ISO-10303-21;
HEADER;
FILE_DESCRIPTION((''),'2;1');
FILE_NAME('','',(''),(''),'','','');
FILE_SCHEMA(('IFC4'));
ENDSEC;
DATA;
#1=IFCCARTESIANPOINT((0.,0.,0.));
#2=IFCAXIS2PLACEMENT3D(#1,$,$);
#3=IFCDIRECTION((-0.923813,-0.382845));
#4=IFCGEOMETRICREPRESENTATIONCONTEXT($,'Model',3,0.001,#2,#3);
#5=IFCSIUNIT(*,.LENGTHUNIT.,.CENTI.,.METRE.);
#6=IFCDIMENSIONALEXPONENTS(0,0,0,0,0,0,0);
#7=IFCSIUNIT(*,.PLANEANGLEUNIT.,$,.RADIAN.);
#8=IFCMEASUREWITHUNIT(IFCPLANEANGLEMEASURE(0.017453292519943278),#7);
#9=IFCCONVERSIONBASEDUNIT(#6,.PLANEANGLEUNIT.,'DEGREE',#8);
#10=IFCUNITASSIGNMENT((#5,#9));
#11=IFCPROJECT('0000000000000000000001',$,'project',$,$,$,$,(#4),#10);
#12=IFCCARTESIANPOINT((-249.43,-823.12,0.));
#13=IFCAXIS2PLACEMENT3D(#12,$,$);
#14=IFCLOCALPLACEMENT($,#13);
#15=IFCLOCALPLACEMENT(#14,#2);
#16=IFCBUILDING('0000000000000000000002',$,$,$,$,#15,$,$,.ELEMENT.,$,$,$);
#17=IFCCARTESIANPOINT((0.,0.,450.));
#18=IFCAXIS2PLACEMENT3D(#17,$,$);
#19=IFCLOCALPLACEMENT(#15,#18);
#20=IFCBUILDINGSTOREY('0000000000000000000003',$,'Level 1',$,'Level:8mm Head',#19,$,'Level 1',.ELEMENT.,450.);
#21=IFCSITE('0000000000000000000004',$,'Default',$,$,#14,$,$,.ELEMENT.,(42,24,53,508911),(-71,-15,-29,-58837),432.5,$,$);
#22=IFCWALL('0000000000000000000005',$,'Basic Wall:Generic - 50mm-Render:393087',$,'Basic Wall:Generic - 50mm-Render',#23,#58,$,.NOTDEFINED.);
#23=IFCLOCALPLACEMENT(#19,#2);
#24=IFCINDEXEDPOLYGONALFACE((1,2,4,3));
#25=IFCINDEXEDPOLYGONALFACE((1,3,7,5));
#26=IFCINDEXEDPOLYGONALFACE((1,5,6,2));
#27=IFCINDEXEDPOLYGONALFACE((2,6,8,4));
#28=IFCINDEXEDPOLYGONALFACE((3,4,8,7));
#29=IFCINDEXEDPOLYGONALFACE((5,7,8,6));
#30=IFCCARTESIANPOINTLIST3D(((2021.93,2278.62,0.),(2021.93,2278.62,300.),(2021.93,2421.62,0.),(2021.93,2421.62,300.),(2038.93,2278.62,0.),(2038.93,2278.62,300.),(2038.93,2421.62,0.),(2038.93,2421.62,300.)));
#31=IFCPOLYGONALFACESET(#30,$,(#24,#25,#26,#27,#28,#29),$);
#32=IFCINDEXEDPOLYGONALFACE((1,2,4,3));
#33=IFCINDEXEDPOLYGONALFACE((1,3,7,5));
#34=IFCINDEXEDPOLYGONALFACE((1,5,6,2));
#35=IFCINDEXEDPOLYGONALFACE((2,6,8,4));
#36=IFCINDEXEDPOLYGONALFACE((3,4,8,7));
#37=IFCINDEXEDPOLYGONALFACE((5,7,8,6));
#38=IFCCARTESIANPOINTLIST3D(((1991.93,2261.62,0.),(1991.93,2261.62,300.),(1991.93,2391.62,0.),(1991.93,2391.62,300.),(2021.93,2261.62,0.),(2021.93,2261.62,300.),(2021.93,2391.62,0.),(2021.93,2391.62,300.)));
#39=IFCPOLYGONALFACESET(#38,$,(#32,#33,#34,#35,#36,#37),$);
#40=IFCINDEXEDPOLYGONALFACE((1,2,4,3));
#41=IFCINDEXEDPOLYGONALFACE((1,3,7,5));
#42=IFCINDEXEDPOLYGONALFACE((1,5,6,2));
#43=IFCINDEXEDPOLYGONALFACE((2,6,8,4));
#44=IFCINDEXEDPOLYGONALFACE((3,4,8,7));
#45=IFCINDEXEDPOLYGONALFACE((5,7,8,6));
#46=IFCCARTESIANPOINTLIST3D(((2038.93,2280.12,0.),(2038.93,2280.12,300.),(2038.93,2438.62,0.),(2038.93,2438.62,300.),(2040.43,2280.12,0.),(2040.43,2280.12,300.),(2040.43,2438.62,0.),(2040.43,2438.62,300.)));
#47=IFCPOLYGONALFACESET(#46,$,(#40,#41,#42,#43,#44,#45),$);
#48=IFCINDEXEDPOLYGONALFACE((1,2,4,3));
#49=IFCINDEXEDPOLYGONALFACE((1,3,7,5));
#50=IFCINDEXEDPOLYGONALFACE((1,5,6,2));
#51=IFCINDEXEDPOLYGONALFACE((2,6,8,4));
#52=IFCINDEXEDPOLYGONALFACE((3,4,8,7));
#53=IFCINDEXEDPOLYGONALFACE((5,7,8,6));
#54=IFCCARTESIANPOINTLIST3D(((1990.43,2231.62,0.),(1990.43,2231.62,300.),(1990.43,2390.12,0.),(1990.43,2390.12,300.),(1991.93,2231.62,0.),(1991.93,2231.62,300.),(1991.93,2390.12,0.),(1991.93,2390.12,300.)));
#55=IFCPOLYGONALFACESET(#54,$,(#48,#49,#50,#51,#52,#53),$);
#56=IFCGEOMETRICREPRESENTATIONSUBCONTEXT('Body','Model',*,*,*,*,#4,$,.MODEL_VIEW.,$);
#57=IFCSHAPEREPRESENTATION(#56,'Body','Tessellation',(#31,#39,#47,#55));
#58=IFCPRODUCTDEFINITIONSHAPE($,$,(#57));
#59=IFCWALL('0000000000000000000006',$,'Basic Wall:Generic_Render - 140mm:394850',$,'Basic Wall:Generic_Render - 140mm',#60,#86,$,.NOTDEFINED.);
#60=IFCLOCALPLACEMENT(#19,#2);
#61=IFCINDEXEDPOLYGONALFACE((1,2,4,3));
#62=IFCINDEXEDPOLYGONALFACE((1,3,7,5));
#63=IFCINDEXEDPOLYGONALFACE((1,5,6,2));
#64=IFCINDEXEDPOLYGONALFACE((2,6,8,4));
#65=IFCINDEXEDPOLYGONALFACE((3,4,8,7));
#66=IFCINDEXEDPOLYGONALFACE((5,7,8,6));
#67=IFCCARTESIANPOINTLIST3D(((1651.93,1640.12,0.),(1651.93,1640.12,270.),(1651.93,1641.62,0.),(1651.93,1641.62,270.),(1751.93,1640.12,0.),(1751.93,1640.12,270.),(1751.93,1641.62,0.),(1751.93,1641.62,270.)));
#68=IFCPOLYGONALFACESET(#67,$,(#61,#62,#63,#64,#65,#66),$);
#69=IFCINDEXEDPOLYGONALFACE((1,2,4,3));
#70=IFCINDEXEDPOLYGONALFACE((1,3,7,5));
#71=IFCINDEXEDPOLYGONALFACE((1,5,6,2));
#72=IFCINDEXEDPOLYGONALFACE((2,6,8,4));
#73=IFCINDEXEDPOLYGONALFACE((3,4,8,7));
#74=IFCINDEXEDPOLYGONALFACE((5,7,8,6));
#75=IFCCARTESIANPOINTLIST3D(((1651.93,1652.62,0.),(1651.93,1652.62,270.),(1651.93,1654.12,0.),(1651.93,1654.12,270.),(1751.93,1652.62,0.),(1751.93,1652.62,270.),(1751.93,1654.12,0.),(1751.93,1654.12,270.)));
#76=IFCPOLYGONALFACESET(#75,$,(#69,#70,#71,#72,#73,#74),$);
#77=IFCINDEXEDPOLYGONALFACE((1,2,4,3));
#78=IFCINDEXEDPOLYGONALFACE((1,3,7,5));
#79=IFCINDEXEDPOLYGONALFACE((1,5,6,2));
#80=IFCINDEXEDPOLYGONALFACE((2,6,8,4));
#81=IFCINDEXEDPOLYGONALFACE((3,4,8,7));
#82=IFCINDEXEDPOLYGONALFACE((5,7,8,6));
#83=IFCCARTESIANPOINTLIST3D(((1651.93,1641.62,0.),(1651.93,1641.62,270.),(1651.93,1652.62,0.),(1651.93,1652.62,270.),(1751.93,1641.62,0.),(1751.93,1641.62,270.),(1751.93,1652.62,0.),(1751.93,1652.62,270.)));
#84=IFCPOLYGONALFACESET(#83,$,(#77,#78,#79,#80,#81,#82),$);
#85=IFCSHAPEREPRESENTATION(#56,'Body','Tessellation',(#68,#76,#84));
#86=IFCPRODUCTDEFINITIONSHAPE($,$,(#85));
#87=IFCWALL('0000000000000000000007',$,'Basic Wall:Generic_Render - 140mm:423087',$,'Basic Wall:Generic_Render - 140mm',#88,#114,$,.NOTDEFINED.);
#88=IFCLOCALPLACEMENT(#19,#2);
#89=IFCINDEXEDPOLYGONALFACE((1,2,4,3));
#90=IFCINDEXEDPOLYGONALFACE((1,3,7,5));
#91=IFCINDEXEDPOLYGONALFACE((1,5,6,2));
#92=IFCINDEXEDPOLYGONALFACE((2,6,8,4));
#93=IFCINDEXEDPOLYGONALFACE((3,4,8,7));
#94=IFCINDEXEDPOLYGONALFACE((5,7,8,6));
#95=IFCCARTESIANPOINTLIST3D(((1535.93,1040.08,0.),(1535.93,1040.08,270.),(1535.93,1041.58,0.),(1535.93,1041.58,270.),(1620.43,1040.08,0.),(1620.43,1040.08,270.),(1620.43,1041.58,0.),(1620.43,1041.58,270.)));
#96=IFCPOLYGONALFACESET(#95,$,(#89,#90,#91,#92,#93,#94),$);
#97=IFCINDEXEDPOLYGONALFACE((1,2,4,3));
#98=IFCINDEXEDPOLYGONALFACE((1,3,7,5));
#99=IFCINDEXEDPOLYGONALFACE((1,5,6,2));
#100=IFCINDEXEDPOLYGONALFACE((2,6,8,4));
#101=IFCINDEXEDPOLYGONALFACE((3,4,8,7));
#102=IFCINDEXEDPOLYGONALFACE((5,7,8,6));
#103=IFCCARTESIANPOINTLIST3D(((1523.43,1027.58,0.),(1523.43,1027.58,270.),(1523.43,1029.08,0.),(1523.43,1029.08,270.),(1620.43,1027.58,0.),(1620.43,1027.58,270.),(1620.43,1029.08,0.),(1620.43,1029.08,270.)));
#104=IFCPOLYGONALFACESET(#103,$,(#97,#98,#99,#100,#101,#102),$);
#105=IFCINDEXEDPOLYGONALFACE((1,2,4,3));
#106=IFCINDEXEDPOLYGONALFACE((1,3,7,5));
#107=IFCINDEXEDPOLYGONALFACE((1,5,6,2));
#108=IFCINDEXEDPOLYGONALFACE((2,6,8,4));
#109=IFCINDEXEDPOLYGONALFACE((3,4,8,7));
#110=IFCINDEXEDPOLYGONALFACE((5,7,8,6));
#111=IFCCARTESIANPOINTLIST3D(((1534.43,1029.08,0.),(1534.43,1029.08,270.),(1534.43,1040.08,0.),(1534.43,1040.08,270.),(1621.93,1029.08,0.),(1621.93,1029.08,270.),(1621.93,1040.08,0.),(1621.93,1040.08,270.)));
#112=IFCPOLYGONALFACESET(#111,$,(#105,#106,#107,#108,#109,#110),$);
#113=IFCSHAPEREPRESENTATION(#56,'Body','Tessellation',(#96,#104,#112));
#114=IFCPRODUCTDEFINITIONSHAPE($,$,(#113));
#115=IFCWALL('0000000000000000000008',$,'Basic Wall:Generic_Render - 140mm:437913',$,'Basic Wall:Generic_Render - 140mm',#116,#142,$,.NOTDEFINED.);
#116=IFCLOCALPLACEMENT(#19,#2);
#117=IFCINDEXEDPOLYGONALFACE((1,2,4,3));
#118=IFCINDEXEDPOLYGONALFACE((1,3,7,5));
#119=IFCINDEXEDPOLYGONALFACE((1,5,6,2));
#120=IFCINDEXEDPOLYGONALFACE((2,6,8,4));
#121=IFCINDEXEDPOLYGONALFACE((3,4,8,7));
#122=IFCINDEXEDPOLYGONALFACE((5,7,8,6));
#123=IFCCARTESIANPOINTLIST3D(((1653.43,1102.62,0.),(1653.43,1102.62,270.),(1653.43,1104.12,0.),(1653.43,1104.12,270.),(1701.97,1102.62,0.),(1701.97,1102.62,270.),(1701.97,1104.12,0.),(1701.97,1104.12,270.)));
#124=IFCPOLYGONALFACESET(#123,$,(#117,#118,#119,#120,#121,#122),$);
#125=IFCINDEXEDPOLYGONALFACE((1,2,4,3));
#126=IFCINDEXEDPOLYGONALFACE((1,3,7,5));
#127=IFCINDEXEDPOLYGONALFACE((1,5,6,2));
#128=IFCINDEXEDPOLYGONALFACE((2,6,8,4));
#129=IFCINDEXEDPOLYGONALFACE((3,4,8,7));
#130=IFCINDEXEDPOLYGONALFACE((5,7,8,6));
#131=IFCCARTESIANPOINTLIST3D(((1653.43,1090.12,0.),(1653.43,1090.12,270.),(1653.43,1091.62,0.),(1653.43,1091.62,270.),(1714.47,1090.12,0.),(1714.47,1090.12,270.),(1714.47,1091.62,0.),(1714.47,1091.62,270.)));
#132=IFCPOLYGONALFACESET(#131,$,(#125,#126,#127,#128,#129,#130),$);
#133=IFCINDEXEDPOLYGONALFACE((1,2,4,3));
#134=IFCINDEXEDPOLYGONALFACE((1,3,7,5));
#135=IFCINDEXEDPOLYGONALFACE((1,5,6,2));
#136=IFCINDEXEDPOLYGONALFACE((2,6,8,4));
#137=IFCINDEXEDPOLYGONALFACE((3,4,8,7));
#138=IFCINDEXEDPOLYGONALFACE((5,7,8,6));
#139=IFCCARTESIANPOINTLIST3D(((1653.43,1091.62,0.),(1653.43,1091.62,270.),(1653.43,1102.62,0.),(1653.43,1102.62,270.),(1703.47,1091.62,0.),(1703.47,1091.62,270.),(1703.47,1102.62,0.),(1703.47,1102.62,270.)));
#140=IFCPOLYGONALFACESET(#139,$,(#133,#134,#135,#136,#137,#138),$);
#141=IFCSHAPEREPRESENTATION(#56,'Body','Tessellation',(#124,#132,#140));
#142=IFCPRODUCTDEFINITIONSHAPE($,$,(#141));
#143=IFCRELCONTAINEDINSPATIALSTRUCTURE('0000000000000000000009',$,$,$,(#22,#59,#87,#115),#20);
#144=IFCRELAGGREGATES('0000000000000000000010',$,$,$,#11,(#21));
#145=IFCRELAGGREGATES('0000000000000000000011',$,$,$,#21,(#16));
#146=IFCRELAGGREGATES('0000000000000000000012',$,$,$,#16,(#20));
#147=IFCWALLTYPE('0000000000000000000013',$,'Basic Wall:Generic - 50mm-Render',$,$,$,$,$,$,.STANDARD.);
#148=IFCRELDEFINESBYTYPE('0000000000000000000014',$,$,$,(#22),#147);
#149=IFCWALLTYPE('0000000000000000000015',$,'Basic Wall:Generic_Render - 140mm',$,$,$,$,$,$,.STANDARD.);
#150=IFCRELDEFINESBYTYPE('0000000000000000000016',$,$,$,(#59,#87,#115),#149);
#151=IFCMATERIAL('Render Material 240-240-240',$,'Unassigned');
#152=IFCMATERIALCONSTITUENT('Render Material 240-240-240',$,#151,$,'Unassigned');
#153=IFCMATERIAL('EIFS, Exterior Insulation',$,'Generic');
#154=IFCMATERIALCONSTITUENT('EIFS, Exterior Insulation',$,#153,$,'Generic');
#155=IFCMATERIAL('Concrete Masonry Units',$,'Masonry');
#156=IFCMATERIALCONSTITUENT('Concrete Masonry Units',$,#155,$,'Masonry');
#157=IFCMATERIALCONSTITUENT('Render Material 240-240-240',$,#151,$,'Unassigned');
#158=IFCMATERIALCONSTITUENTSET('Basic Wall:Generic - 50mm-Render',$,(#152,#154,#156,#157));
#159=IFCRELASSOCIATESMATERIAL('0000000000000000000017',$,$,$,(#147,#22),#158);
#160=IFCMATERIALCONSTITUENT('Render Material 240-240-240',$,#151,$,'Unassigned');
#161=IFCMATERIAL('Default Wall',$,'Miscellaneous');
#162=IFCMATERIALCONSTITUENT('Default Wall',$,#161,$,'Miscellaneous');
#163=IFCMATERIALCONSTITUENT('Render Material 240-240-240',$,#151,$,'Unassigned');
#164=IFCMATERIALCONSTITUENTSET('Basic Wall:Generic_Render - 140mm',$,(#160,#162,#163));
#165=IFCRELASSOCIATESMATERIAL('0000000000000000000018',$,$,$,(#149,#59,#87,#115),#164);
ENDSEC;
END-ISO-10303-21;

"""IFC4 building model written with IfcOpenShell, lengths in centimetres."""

from ifc_helpers import new_model, entity, si_unit, converted_unit, direction, frame, origin, place, context, subcontext, project, spatial, indexed_curve, outline, extrude, material, constituent, constituent_set, type_object, element, save


model = new_model("IFC4")

# Units and contexts
model_context = context("Model", 3, precision=0.001, world=origin(), true_north=direction((-0.923813, -0.382845)))
body_context = subcontext(model_context, "Body", "Model", "MODEL_VIEW")
ifc_project = project(units=[si_unit("LENGTHUNIT", "METRE", prefix="CENTI"), converted_unit("PLANEANGLEUNIT", "DEGREE", entity("IfcPlaneAngleMeasure", 0.017453292519943278), si_unit("PLANEANGLEUNIT", "RADIAN"), dimensions=[0, 0, 0, 0, 0, 0, 0])], contexts=[model_context])

# Site, building, storey
site_placement = place(None, frame((-249.43, -823.12, 0.0)))
site = spatial("IfcSite", under=ifc_project, at=site_placement, Name="Default", CompositionType="ELEMENT", RefLatitude=(42, 24, 53, 508911), RefLongitude=(-71, -15, -29, -58837), RefElevation=432.5)
building_placement = place(site_placement, origin())
building = spatial("IfcBuilding", under=site, at=building_placement, CompositionType="ELEMENT")
storey_placement = place(building_placement, frame((0.0, 0.0, 450.0)))
storey = spatial("IfcBuildingStorey", under=building, at=storey_placement, Name="Level 1", ObjectType="Level:8mm Head", LongName="Level 1", CompositionType="ELEMENT", Elevation=450.0)

# Wall
ifc_material_1 = material(Name="Concrete Masonry Units", Category="Masonry")
ifc_material_2 = material(Name="Render Material 240-240-240", Category="Unassigned")
ifc_material_3 = material(Name="Default Wall", Category="Miscellaneous")
ifc_constituent_1 = constituent(ifc_material_2, Name="Render Material 240-240-240", Category="Unassigned")
ifc_material_4 = material(Name="EIFS, Exterior Insulation", Category="Generic")
ifc_constituent_2 = constituent(ifc_material_4, Name="EIFS, Exterior Insulation", Category="Generic")
ifc_constituent_3 = constituent(ifc_material_1, Name="Concrete Masonry Units", Category="Masonry")
ifc_constituent_4 = constituent(ifc_material_2, Name="Render Material 240-240-240", Category="Unassigned")
ifc_constituent_set_1 = constituent_set(constituents=[ifc_constituent_1, ifc_constituent_2, ifc_constituent_3, ifc_constituent_4], Name="Basic Wall:Generic - 50mm-Render")
wall_type_1 = type_object("IfcWallType", Name="Basic Wall:Generic - 50mm-Render", PredefinedType="STANDARD", material=ifc_constituent_set_1)
wall_1_placement = place(storey_placement, frame((2015.43, 2280.12, 0.0), z_axis=(0.0, 0.0, 1.0), x_axis=(0.0, 1.0, 0.0)))
element("IfcWall", 1, at=wall_1_placement, inside=storey, type_object=wall_type_1, material=ifc_constituent_set_1, Name="Basic Wall:Generic - 50mm-Render:393087", ObjectType="Basic Wall:Generic - 50mm-Render", PredefinedType="NOTDEFINED", context=body_context, shape_type="SweptSolid", body=[
    extrude(outline(indexed_curve([(-8.5, -71.5), (8.5, -71.5), (8.5, 71.5), (-8.5, 71.5), (-8.5, -71.5)], self_intersect=False)), frame((70.0, -15.0, 0.0), z_axis=(0.0, 0.0, 1.0), x_axis=(0.0, 1.0, 0.0)), (0.0, 0.0, 1.0), 300.0),
    extrude(outline(indexed_curve([(-15.0, -65.0), (15.0, -65.0), (15.0, 65.0), (-15.0, 65.0), (-15.0, -65.0)], self_intersect=False)), frame((46.5, 8.5, 0.0), z_axis=(0.0, 0.0, 1.0), x_axis=(0.0, -1.0, 0.0)), (0.0, 0.0, 1.0), 300.0),
    extrude(outline(indexed_curve([(-0.75, -79.25), (0.75, -79.25), (0.75, 79.25), (-0.75, 79.25), (-0.75, -79.25)], self_intersect=False)), frame((79.25, -24.25, 0.0), z_axis=(0.0, 0.0, 1.0), x_axis=(0.0, 1.0, 0.0)), (0.0, 0.0, 1.0), 300.0),
    extrude(outline(indexed_curve([(-0.75, -79.25), (0.75, -79.25), (0.75, 79.25), (-0.75, 79.25), (-0.75, -79.25)], self_intersect=False)), frame((30.75, 24.25, 0.0), z_axis=(0.0, 0.0, 1.0), x_axis=(0.0, 1.0, 0.0)), (0.0, 0.0, 1.0), 300.0),
])

# Walls
ifc_constituent_5 = constituent(ifc_material_2, Name="Render Material 240-240-240", Category="Unassigned")
ifc_constituent_6 = constituent(ifc_material_3, Name="Default Wall", Category="Miscellaneous")
ifc_constituent_7 = constituent(ifc_material_2, Name="Render Material 240-240-240", Category="Unassigned")
ifc_constituent_set_2 = constituent_set(constituents=[ifc_constituent_5, ifc_constituent_6, ifc_constituent_7], Name="Basic Wall:Generic_Render - 140mm")
wall_type_2 = type_object("IfcWallType", Name="Basic Wall:Generic_Render - 140mm", PredefinedType="STANDARD", material=ifc_constituent_set_2)
wall_2_placement = place(storey_placement, frame((1651.93, 1647.12, 0.0)))
element("IfcWall", 2, at=wall_2_placement, inside=storey, type_object=wall_type_2, material=ifc_constituent_set_2, Name="Basic Wall:Generic_Render - 140mm:394850", ObjectType="Basic Wall:Generic_Render - 140mm", PredefinedType="NOTDEFINED", context=body_context, shape_type="SweptSolid", body=[
    extrude(outline(indexed_curve([(-0.75, -50.0), (0.75, -50.0), (0.75, 50.0), (-0.75, 50.0), (-0.75, -50.0)], self_intersect=False)), frame((50.0, -6.25, 0.0), z_axis=(0.0, 0.0, 1.0), x_axis=(0.0, 1.0, 0.0)), (0.0, 0.0, 1.0), 270.0),
    extrude(outline(indexed_curve([(-0.75, -50.0), (0.75, -50.0), (0.75, 50.0), (-0.75, 50.0), (-0.75, -50.0)], self_intersect=False)), frame((50.0, 6.25, 0.0), z_axis=(0.0, 0.0, 1.0), x_axis=(0.0, -1.0, 0.0)), (0.0, 0.0, 1.0), 270.0),
    extrude(outline(indexed_curve([(-50.0, -5.5), (50.0, -5.5), (50.0, 5.5), (-50.0, 5.5), (-50.0, -5.5)], self_intersect=False)), frame((50.0, 0.0, 0.0)), (0.0, 0.0, 1.0), 270.0),
])
wall_3_placement = place(storey_placement, frame((1535.93, 1034.58, 0.0)))
element("IfcWall", 3, at=wall_3_placement, inside=storey, type_object=wall_type_2, material=ifc_constituent_set_2, Name="Basic Wall:Generic_Render - 140mm:423087", ObjectType="Basic Wall:Generic_Render - 140mm", PredefinedType="NOTDEFINED", context=body_context, shape_type="SweptSolid", body=[
    extrude(outline(indexed_curve([(-0.75, -42.25), (0.75, -42.25), (0.75, 42.25), (-0.75, 42.25), (-0.75, -42.25)], self_intersect=False)), frame((42.25, 6.25, 0.0), z_axis=(0.0, 0.0, 1.0), x_axis=(0.0, -1.0, 0.0)), (0.0, 0.0, 1.0), 270.0),
    extrude(outline(indexed_curve([(-0.75, -48.5), (0.75, -48.5), (0.75, 48.5), (-0.75, 48.5), (-0.75, -48.5)], self_intersect=False)), frame((36.0, -6.25, 0.0), z_axis=(0.0, 0.0, 1.0), x_axis=(0.0, 1.0, 0.0)), (0.0, 0.0, 1.0), 270.0),
    extrude(outline(indexed_curve([(-43.75, -5.5), (43.75, -5.5), (43.75, 5.5), (-43.75, 5.5), (-43.75, -5.5)], self_intersect=False)), frame((42.25, 0.0, 0.0)), (0.0, 0.0, 1.0), 270.0),
])
wall_4_placement = place(storey_placement, frame((1701.97, 1097.12, 0.0), z_axis=(0.0, 0.0, 1.0), x_axis=(-1.0, 0.0, 0.0)))
element("IfcWall", 4, at=wall_4_placement, inside=storey, type_object=wall_type_2, material=ifc_constituent_set_2, Name="Basic Wall:Generic_Render - 140mm:437913", ObjectType="Basic Wall:Generic_Render - 140mm", PredefinedType="NOTDEFINED", context=body_context, shape_type="SweptSolid", body=[
    extrude(outline(indexed_curve([(-0.75, -24.27), (0.75, -24.27), (0.75, 24.27), (-0.75, 24.27), (-0.75, -24.27)], self_intersect=False)), frame((24.27, -6.25, 0.0), z_axis=(0.0, 0.0, 1.0), x_axis=(0.0, 1.0, 0.0)), (0.0, 0.0, 1.0), 270.0),
    extrude(outline(indexed_curve([(-0.75, -30.52), (0.75, -30.52), (0.75, 30.52), (-0.75, 30.52), (-0.75, -30.52)], self_intersect=False)), frame((18.02, 6.25, 0.0), z_axis=(0.0, 0.0, 1.0), x_axis=(0.0, -1.0, 0.0)), (0.0, 0.0, 1.0), 270.0),
    extrude(outline(indexed_curve([(-25.02, -5.5), (25.02, -5.5), (25.02, 5.5), (-25.02, 5.5), (-25.02, -5.5)], self_intersect=False)), frame((23.52, 0.0, 0.0)), (0.0, 0.0, 1.0), 270.0),
])

save(model, "model.ifc")
